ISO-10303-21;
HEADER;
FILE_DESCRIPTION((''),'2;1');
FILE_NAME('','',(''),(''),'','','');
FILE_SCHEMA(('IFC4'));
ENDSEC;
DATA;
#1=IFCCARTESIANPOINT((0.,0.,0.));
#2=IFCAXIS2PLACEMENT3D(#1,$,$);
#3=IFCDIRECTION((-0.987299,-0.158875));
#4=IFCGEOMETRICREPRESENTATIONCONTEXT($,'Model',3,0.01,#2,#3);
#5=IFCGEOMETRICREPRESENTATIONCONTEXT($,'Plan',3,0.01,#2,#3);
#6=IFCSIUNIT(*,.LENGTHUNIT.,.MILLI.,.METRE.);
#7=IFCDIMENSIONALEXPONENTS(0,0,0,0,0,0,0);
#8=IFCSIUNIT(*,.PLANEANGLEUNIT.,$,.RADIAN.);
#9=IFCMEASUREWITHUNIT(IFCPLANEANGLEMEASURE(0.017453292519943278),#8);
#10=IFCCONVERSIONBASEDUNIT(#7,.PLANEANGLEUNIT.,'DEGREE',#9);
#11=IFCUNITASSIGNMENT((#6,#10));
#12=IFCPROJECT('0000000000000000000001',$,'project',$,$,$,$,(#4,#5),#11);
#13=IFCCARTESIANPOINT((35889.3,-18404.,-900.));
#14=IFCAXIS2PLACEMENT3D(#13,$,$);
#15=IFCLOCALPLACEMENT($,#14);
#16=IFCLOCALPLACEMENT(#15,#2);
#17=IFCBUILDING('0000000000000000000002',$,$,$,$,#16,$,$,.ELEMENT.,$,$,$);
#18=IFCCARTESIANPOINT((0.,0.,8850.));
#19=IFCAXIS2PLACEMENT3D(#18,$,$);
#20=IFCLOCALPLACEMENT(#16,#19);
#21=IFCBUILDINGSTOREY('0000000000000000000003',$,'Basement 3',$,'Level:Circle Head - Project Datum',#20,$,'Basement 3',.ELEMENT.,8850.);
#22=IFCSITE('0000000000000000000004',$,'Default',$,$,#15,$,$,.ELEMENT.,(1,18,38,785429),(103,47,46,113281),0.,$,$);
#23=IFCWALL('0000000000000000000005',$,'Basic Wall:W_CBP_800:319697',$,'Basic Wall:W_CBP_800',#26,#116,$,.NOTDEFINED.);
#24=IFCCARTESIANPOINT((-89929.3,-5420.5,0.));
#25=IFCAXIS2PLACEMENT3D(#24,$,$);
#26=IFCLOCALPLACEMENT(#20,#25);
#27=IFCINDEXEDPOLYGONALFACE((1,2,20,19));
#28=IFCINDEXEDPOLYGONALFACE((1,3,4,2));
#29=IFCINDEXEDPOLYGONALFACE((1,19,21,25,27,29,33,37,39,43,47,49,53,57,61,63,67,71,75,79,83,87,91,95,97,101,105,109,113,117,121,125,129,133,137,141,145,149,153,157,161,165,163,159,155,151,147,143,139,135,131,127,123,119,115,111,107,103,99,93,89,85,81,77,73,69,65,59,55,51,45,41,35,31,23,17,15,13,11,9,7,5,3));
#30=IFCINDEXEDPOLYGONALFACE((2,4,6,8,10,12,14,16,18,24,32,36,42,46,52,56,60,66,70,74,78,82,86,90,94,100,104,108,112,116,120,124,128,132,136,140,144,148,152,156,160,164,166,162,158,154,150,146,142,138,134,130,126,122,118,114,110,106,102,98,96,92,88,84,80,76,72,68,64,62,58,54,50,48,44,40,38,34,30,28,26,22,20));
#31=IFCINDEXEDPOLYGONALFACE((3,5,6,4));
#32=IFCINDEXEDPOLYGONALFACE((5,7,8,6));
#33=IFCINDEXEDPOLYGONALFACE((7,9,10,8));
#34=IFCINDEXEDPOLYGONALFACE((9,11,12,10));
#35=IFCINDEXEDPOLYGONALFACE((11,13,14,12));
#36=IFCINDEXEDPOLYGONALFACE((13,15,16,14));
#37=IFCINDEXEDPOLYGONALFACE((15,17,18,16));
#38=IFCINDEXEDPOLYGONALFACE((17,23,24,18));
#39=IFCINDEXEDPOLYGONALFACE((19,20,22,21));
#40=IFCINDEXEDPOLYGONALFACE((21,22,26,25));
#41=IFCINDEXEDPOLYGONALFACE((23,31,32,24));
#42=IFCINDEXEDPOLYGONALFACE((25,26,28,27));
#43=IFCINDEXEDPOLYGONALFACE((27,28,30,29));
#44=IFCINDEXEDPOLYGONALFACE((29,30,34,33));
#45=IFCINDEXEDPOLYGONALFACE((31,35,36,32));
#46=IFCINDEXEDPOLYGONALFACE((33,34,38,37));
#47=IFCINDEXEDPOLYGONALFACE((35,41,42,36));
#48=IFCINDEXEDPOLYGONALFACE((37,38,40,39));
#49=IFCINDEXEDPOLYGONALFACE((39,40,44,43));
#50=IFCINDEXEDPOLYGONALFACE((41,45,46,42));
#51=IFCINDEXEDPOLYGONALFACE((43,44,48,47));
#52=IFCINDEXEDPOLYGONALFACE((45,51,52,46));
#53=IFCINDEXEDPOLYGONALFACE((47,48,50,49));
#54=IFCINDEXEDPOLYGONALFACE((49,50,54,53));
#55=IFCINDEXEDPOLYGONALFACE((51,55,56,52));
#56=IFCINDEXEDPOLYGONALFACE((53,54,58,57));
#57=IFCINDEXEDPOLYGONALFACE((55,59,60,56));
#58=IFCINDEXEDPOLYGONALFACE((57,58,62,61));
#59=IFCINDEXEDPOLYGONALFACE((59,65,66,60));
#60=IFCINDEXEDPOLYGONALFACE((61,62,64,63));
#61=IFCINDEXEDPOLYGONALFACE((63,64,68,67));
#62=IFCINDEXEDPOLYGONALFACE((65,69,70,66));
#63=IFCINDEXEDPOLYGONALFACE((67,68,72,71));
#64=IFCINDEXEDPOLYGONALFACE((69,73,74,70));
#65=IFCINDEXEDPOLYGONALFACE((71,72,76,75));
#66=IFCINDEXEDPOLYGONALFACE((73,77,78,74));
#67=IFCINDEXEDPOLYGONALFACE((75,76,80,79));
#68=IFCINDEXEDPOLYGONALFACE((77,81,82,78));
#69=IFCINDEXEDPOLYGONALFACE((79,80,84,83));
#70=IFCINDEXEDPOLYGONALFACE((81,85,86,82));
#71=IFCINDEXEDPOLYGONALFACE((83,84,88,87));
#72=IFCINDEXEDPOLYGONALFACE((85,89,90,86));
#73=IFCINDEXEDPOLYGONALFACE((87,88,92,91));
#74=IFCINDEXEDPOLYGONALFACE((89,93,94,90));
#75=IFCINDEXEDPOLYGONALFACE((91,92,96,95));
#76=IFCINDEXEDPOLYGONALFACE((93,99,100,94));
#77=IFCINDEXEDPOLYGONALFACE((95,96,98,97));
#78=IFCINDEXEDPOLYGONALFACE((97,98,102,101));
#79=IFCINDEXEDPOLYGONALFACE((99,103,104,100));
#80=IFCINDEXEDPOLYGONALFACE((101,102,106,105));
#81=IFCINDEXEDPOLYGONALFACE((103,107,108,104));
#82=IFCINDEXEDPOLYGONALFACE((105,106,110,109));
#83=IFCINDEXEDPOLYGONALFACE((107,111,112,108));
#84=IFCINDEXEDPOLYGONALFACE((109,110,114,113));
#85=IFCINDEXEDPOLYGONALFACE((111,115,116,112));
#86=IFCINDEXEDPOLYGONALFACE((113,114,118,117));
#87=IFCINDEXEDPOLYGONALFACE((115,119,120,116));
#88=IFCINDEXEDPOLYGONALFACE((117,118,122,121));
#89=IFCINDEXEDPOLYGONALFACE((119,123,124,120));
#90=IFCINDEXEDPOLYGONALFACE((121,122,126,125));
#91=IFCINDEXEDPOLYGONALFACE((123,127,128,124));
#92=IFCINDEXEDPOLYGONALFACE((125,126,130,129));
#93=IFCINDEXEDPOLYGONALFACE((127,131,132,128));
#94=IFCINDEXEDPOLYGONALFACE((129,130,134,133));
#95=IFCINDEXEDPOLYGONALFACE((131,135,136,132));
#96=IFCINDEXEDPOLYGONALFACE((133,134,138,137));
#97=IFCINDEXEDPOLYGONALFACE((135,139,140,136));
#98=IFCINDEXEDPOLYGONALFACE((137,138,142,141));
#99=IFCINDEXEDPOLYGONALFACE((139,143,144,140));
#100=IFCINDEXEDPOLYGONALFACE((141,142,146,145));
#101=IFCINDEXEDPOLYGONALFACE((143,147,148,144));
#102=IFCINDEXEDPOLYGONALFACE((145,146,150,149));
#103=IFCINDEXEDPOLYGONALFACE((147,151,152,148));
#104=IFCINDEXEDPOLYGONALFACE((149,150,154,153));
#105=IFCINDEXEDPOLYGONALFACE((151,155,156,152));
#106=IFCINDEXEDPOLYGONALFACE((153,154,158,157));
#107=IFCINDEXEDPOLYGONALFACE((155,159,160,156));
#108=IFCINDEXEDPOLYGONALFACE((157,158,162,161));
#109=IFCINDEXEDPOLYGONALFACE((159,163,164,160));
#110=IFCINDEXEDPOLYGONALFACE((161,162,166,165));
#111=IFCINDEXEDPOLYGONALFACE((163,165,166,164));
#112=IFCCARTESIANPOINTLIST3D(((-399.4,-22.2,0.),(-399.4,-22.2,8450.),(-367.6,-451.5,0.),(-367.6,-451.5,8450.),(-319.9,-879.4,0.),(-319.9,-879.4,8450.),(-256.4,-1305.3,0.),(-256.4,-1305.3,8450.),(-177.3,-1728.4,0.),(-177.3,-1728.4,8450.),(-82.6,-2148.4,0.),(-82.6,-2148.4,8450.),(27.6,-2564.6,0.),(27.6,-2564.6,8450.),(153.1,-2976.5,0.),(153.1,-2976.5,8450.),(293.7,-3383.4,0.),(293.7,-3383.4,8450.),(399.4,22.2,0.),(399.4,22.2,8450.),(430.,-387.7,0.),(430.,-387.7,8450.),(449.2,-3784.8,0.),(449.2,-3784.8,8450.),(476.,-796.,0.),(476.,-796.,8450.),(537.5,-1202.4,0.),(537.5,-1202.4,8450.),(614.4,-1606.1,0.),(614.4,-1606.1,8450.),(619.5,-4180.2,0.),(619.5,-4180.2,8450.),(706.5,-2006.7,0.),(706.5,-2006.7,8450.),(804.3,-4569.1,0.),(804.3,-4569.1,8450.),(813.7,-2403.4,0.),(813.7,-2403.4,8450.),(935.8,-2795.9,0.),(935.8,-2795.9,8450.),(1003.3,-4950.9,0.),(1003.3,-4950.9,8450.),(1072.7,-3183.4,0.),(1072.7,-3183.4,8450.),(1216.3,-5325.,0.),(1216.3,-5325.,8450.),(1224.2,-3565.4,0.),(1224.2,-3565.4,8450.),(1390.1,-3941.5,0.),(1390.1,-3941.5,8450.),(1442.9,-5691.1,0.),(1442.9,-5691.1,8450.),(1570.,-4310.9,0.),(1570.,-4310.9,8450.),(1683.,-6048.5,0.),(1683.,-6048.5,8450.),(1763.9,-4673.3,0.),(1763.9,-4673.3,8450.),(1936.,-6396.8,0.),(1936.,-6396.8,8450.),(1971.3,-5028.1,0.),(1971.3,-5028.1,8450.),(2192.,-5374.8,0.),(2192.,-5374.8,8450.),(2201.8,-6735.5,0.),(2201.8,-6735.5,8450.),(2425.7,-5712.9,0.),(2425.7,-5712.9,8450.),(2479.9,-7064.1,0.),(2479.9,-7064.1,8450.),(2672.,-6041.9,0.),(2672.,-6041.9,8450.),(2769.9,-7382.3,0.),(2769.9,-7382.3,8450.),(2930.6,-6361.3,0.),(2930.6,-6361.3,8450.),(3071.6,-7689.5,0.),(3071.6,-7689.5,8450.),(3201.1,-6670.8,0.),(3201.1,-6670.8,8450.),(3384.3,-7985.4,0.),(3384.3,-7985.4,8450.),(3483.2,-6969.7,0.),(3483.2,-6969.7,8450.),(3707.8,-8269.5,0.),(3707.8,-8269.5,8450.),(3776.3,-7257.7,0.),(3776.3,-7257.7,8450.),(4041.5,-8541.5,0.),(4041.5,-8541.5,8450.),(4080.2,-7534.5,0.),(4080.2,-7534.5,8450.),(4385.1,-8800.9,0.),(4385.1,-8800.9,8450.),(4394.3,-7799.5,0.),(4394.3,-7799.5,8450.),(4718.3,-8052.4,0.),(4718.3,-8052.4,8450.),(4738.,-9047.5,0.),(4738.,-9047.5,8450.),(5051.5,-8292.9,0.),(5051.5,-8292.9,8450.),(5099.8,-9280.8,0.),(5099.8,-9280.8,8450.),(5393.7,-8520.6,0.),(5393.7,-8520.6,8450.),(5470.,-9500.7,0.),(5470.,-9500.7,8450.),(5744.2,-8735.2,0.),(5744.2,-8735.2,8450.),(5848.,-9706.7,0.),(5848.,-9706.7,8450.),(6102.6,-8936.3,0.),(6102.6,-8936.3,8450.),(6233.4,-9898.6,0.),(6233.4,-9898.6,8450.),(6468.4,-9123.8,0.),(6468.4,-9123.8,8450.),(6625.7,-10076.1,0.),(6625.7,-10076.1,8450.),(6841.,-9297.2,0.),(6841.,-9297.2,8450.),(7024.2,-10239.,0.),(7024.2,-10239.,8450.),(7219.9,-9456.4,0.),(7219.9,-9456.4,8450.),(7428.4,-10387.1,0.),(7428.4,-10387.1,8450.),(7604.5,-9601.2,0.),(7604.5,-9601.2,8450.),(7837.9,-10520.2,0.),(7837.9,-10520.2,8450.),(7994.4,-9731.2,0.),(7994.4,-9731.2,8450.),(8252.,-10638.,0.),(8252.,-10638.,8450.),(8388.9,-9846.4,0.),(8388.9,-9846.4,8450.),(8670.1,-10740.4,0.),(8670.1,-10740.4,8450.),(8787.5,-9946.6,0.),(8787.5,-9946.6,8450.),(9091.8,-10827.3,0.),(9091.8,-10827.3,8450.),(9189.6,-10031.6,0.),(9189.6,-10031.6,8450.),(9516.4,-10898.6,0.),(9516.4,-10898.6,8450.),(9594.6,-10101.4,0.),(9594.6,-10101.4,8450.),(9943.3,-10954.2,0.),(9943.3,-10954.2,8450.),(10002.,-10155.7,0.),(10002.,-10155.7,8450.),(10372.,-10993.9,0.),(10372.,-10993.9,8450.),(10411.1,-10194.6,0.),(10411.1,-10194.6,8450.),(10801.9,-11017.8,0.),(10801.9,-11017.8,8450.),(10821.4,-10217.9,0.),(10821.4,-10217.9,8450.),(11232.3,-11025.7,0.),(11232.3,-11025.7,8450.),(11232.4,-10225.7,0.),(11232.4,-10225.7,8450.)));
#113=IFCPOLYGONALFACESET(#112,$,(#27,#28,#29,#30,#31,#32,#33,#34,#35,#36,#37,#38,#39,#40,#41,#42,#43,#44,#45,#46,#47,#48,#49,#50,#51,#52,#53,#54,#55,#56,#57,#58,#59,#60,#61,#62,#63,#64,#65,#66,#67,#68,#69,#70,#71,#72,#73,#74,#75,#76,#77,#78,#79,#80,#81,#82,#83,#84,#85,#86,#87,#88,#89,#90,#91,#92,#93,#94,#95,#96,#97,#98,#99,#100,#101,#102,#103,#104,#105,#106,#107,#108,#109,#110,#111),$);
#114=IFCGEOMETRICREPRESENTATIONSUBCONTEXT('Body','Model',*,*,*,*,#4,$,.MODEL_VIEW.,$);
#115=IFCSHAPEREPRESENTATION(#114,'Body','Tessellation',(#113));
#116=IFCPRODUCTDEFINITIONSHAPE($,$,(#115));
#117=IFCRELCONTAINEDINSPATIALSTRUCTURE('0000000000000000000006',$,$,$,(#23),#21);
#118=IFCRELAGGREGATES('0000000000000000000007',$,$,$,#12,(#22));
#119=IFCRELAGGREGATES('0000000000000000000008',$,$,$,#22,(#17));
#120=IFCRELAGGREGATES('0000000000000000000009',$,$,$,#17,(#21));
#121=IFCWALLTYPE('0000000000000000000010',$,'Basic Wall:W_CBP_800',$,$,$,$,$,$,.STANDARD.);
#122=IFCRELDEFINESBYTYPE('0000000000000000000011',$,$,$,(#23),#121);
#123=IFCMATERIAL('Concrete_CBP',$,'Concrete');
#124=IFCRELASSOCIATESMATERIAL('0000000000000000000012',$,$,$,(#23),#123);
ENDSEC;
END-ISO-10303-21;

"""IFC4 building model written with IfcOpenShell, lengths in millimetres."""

from ifc_helpers import new_model, entity, si_unit, converted_unit, direction, frame, origin, place, context, subcontext, project, spatial, line, arc, indexed_curve, outline, extrude, material, type_object, element, save


model = new_model("IFC4")

# Units and contexts
model_context = context("Model", 3, precision=0.01, world=origin(), true_north=direction((-0.987299, -0.158875)))
plan_context = context("Plan", 3, precision=0.01, world=origin(), true_north=direction((-0.987299, -0.158875)))
body_context = subcontext(model_context, "Body", "Model", "MODEL_VIEW")
ifc_project = project(units=[si_unit("LENGTHUNIT", "METRE", prefix="MILLI"), converted_unit("PLANEANGLEUNIT", "DEGREE", entity("IfcPlaneAngleMeasure", 0.017453292519943278), si_unit("PLANEANGLEUNIT", "RADIAN"), dimensions=[0, 0, 0, 0, 0, 0, 0])], contexts=[model_context, plan_context])

# Site, building, storey
site_placement = place(None, frame((35889.3, -18404.0, -900.0)))
site = spatial("IfcSite", under=ifc_project, at=site_placement, Name="Default", CompositionType="ELEMENT", RefLatitude=(1, 18, 38, 785429), RefLongitude=(103, 47, 46, 113281), RefElevation=0.0)
building_placement = place(site_placement, origin())
building = spatial("IfcBuilding", under=site, at=building_placement, CompositionType="ELEMENT")
storey_placement = place(building_placement, frame((0.0, 0.0, 8850.0)))
storey = spatial("IfcBuildingStorey", under=building, at=storey_placement, Name="Basement 3", ObjectType="Level:Circle Head - Project Datum", LongName="Basement 3", CompositionType="ELEMENT", Elevation=8850.0)

# Wall
ifc_material_1 = material(Name="Concrete_CBP", Category="Concrete")
wall_type_1 = type_object("IfcWallType", Name="Basic Wall:W_CBP_800", PredefinedType="STANDARD")
wall_1_placement = place(storey_placement, frame((-89929.3, -5420.5, 0.0)))
element("IfcWall", 1, at=wall_1_placement, inside=storey, type_object=wall_type_1, material=ifc_material_1, Name="Basic Wall:W_CBP_800:319697", ObjectType="Basic Wall:W_CBP_800", PredefinedType="NOTDEFINED", context=body_context, shape_type="SweptSolid", body=[
    extrude(outline(indexed_curve([(11232.4, -10225.7), (3776.3, -7257.7), (399.4, 22.2), (-399.4, -22.2), (3226.6, -7838.9), (11232.3, -11025.7)], segments=[arc(1, 2, 3), line(3, 4), arc(4, 5, 6), line(6, 1)], self_intersect=False)), origin(), (0.0, 0.0, 1.0), 8450.0),
])

save(model, "model.ifc")
